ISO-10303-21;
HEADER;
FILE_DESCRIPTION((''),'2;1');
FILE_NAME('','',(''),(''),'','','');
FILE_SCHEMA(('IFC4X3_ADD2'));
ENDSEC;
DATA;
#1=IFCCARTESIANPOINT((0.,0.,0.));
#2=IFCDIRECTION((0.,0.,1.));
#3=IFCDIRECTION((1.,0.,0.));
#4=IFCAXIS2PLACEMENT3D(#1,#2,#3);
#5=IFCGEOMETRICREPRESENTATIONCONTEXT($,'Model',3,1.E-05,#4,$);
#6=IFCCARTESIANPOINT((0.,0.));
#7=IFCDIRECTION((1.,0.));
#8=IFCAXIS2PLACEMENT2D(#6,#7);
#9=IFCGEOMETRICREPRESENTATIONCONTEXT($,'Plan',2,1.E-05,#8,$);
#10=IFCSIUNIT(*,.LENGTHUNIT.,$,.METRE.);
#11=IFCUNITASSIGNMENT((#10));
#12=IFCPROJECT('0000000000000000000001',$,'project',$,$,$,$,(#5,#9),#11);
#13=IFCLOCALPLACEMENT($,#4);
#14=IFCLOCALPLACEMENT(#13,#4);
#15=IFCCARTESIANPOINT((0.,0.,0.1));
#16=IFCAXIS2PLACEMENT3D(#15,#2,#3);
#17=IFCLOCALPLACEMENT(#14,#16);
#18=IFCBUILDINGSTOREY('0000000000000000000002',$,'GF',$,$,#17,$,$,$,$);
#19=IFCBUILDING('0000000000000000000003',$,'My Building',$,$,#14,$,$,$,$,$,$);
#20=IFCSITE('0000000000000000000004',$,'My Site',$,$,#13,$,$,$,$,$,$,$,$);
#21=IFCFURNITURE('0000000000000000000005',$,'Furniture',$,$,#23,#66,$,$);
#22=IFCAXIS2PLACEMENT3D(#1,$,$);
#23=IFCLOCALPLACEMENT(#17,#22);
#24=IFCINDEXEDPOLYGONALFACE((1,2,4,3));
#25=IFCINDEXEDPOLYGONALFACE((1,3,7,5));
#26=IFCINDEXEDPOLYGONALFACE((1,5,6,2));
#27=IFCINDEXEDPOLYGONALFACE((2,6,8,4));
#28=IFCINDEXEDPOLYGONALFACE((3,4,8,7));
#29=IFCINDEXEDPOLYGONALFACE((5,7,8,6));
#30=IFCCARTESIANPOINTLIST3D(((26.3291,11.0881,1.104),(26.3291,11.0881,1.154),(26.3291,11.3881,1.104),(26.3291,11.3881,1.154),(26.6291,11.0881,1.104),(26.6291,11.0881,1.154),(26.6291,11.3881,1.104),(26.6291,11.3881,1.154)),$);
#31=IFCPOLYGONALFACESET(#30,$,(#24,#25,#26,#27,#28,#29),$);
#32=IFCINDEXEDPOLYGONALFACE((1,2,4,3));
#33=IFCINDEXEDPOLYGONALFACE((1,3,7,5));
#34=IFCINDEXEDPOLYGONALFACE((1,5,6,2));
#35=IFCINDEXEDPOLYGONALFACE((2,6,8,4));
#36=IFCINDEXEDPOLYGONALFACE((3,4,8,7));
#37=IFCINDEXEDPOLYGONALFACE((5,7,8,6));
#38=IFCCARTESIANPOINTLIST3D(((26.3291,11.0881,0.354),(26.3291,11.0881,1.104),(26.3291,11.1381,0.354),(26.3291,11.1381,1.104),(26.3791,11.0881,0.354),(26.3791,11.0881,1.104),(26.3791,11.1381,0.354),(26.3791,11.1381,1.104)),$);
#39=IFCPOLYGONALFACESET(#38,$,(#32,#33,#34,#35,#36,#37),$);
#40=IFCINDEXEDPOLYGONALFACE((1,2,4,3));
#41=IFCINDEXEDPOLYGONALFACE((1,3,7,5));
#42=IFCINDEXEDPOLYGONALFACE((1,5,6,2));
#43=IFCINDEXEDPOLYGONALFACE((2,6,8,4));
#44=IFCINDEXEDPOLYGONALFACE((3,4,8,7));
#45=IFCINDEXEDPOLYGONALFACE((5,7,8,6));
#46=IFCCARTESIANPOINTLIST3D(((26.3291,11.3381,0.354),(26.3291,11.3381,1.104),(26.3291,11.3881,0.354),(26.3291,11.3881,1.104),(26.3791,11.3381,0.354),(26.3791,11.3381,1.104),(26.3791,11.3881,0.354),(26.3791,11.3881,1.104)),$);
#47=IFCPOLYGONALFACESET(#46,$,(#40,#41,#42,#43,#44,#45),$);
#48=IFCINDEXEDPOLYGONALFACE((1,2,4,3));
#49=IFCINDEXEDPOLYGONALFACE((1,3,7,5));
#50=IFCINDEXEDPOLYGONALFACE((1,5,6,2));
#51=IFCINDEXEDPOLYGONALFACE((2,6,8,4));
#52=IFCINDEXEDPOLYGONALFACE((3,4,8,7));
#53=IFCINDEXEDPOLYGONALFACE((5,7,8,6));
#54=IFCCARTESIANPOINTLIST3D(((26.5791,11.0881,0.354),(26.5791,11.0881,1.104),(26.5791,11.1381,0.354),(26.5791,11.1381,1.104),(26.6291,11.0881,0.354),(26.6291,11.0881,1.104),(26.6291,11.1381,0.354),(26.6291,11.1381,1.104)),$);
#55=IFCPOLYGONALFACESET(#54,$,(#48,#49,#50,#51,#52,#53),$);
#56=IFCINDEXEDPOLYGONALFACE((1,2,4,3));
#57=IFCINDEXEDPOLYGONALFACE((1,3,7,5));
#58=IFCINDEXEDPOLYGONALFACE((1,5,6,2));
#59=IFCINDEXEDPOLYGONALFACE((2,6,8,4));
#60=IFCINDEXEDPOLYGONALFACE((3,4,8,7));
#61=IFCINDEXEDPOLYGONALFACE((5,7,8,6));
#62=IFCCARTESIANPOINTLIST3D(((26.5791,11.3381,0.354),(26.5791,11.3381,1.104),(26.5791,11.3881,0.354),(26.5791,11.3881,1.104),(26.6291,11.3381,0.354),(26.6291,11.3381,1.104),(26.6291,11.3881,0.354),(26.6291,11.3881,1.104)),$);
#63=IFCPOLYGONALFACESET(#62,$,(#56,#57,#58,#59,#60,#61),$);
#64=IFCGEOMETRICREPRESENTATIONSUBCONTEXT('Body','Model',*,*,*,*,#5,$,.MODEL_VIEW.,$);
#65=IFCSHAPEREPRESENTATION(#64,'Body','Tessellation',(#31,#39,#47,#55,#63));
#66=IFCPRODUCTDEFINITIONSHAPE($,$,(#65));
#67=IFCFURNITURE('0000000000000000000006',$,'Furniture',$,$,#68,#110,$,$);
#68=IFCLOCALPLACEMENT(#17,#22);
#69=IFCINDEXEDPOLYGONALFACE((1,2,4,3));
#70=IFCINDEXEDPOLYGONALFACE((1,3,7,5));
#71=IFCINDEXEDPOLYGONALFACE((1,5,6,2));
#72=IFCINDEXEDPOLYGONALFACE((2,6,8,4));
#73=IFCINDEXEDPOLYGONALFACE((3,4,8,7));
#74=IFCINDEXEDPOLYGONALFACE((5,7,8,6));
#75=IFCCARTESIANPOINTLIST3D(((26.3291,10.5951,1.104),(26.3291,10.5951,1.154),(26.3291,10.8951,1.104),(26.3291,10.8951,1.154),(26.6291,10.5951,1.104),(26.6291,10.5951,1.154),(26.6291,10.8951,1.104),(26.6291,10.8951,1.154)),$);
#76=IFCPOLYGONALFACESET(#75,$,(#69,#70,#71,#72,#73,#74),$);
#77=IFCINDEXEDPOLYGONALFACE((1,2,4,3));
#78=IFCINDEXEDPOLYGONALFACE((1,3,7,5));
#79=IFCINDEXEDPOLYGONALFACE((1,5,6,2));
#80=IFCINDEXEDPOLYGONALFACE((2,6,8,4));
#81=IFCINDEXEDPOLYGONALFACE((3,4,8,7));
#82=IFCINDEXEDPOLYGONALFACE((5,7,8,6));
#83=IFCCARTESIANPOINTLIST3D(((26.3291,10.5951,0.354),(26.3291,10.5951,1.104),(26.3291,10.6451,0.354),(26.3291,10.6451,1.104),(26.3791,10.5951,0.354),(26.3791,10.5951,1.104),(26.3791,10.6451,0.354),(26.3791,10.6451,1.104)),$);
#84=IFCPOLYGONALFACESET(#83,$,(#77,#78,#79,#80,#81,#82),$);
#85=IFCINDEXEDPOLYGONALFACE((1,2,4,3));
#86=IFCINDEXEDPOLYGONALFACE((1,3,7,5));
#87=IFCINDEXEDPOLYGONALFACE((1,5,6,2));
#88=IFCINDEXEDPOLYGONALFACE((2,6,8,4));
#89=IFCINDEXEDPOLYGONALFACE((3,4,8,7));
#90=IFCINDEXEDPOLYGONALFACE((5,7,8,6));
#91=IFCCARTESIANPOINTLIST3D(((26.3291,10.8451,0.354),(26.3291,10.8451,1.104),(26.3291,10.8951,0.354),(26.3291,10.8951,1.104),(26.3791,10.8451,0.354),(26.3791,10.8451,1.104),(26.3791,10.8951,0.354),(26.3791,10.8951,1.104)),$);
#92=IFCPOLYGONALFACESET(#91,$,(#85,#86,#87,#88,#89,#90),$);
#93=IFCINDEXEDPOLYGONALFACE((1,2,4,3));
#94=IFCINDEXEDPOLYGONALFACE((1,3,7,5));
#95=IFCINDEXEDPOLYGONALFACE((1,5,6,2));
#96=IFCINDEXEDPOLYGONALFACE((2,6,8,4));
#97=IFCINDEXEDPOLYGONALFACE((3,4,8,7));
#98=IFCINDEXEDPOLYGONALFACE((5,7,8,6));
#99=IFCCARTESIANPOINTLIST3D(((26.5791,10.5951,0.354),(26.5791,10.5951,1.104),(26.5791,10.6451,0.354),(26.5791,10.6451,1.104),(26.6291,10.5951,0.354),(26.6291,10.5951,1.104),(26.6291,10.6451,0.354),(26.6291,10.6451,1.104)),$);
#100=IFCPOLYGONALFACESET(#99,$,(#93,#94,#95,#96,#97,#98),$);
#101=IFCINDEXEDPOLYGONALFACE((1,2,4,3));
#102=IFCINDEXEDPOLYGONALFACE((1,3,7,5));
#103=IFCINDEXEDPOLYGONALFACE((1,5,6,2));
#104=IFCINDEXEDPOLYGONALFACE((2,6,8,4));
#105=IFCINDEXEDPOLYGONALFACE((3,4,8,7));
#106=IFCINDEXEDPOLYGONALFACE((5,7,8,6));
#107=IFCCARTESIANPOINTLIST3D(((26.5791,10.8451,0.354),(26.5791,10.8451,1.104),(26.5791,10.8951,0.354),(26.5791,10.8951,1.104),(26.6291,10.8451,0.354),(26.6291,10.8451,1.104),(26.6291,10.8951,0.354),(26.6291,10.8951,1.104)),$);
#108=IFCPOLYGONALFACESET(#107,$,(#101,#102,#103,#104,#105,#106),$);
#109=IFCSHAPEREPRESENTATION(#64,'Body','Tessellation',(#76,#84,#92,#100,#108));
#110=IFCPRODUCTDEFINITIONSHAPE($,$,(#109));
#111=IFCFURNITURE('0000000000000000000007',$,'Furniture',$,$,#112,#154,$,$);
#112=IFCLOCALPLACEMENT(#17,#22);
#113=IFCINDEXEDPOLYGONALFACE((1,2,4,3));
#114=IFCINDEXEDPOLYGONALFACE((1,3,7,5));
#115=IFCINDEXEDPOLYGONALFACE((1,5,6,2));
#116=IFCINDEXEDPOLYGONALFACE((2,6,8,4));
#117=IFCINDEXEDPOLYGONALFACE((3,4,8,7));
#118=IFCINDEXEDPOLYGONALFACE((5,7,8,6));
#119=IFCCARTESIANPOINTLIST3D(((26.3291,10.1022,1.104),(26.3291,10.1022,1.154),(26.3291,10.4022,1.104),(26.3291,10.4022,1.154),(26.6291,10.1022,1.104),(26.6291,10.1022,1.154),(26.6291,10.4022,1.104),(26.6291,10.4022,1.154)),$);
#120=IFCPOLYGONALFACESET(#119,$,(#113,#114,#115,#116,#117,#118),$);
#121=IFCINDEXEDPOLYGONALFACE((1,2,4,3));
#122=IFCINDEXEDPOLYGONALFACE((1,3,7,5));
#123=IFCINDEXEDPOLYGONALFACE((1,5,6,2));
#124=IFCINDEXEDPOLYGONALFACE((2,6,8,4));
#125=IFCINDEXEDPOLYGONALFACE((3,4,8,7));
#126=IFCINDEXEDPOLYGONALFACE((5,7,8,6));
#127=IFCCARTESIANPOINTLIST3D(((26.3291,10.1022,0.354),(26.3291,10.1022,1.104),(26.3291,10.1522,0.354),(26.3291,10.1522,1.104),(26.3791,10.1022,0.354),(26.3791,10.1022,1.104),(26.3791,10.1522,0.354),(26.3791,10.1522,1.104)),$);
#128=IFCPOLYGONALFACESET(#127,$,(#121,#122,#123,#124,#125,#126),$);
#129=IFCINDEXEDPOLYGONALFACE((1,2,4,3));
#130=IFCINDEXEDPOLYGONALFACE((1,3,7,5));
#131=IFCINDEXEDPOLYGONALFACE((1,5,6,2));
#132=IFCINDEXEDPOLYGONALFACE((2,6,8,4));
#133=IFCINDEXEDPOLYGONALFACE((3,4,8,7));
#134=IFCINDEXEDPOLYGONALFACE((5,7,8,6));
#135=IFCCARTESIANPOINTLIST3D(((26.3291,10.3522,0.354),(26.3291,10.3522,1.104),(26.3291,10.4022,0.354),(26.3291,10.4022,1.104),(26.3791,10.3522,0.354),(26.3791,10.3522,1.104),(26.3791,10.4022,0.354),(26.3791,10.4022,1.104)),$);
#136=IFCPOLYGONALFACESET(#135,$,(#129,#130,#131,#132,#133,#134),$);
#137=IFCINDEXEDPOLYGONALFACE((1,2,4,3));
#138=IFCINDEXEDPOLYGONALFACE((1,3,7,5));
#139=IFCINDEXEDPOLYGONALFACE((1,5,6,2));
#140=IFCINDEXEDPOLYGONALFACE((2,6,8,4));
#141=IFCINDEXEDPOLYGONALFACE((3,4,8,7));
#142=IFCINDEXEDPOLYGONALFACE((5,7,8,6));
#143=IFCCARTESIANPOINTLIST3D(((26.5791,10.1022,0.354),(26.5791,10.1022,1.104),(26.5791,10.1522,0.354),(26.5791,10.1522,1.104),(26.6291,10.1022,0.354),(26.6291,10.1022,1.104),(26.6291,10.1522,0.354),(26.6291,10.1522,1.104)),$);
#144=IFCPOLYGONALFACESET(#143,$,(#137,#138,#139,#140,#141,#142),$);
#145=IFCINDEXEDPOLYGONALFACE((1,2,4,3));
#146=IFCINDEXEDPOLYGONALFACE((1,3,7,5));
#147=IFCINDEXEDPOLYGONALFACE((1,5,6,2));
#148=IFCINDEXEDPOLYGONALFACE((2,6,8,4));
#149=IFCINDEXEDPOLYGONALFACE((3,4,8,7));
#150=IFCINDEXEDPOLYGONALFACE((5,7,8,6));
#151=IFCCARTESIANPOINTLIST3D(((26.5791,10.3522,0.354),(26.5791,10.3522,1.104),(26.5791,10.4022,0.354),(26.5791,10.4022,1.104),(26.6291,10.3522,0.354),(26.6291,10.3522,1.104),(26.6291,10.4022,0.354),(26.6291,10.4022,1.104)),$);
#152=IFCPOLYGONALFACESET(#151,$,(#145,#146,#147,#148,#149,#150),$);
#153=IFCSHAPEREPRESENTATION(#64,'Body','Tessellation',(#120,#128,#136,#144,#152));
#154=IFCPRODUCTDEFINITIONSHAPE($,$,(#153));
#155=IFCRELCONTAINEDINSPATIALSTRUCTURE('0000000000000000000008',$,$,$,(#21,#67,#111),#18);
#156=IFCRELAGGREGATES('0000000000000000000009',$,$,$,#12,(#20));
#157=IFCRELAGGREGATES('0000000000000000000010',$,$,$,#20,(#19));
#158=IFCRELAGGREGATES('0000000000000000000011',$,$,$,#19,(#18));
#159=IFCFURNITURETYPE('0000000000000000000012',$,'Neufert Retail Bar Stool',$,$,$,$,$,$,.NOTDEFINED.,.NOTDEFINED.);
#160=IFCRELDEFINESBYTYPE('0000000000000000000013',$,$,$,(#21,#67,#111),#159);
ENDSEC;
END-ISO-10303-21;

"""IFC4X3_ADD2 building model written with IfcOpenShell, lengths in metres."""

from ifc_helpers import new_model, entity, si_unit, frame, origin_with_axes, origin_2d_with_axis, place, context, subcontext, project, spatial, line, indexed_curve, outline, extrude, shape, source, transform, mapped, type_object, type_shapes, element, save


model = new_model("IFC4X3_ADD2")

# Units and contexts
model_context = context("Model", 3, precision=1e-05, world=origin_with_axes())
plan_context = context("Plan", 2, precision=1e-05, world=origin_2d_with_axis())
body_context_1 = subcontext(model_context, "Body", "Model", "MODEL_VIEW")
body_context_2 = subcontext(plan_context, "Body", "Plan", "PLAN_VIEW")
ifc_project = project(units=[si_unit("LENGTHUNIT", "METRE")], contexts=[model_context, plan_context])

# Site, building, storey
site_placement = place(None, origin_with_axes())
site = spatial("IfcSite", under=ifc_project, at=site_placement, Name="My Site")
building_placement = place(site_placement, origin_with_axes())
building = spatial("IfcBuilding", under=site, at=building_placement, Name="My Building")
storey_placement = place(building_placement, frame((0.0, 0.0, 0.1), z_axis=(0.0, 0.0, 1.0), x_axis=(1.0, 0.0, 0.0)))
storey = spatial("IfcBuildingStorey", under=building, at=storey_placement, Name="GF")

# Furniture
furniture_type = type_object("IfcFurnitureType", Name="Neufert Retail Bar Stool", AssemblyPlace="NOTDEFINED", PredefinedType="NOTDEFINED")
shared_shape_1 = source(origin_with_axes(), body_context_1, "Body", "SweptSolid", [
    extrude(outline(indexed_curve([(0.15, 0.0), (-0.15, 0.0), (-0.15, -0.3), (0.15, -0.3)], segments=[line(3, 2), line(2, 1), line(1, 4), line(4, 3)], self_intersect=False)), frame((0.0, 0.0, 0.8), z_axis=(0.0, 0.0, 1.0), x_axis=(1.0, 0.0, 0.0)), (0.0, 0.0, -1.0), 0.05),
    extrude(outline(indexed_curve([(-0.15, 0.0), (-0.1, 0.0), (-0.1, -0.05), (-0.15, -0.05)], segments=[line(1, 2, 3, 4, 1)])), origin_with_axes(), (0.0, 0.0, 1.0), 0.75),
    extrude(outline(indexed_curve([(0.15, 0.0), (0.1, 0.0), (0.1, -0.05), (0.15, -0.05)], segments=[line(1, 2, 3, 4, 1)])), origin_with_axes(), (0.0, 0.0, 1.0), 0.75),
    extrude(outline(indexed_curve([(-0.15, -0.3), (-0.1, -0.3), (-0.1, -0.25), (-0.15, -0.25)], segments=[line(1, 2, 3, 4, 1)])), origin_with_axes(), (0.0, 0.0, 1.0), 0.75),
    extrude(outline(indexed_curve([(0.15, -0.3), (0.1, -0.3), (0.1, -0.25), (0.15, -0.25)], segments=[line(1, 2, 3, 4, 1)])), origin_with_axes(), (0.0, 0.0, 1.0), 0.75),
])
shared_shape_2 = source(origin_with_axes(), body_context_2, "Body", "Curve2D", [
    entity("IfcIndexedPolyCurve", entity("IfcCartesianPointList2D", [[-0.15, -0.3], [0.15, -0.3]])),
    entity("IfcIndexedPolyCurve", entity("IfcCartesianPointList2D", [[-0.15, -0.3], [-0.15, -0.15], [-0.1061, -0.0439], [0.0, 0.0], [0.1061, -0.0439], [0.15, -0.15], [0.15, -0.3]]), [entity("IfcLineIndex", [1, 2]), entity("IfcArcIndex", [2, 3, 4]), entity("IfcArcIndex", [4, 5, 6]), entity("IfcLineIndex", [6, 7])]),
    entity("IfcIndexedPolyCurve", entity("IfcCartesianPointList2D", [[-0.12, -0.3], [-0.12, -0.15], [-0.0849, -0.0651], [0.0, -0.03], [0.0849, -0.0651], [0.12, -0.15], [0.12, -0.3]]), [entity("IfcLineIndex", [1, 2]), entity("IfcArcIndex", [2, 3, 4]), entity("IfcArcIndex", [4, 5, 6]), entity("IfcLineIndex", [6, 7])]),
])
type_shapes(furniture_type, [shared_shape_1, shared_shape_2])
for number, where, z_axis, x_axis, name in (
    (1, (26.3291, 11.2381, 0.354), (0.0, 0.0, 1.0), (0.0, 1.0, 0.0), "Furniture"),
    (2, (26.3291, 10.7451, 0.354), (0.0, 0.0, 1.0), (0.0, 1.0, 0.0), "Furniture"),
    (3, (26.3291, 10.2522, 0.354), (0.0, 0.0, 1.0), (0.0, 1.0, 0.0), "Furniture"),
):
    element("IfcFurniture", number, at=place(storey_placement, frame(where, z_axis=z_axis, x_axis=x_axis)), inside=storey, type_object=furniture_type, Name=name, shapes=[
        shape(body_context_1, "Body", "MappedRepresentation", [mapped(shared_shape_1, transform((0.0, 0.0, 0.0), x_axis=(1.0, 0.0, 0.0), y_axis=(0.0, 1.0, 0.0), z_axis=(0.0, 0.0, 1.0), scale=1.0))]),
        shape(body_context_2, "Body", "MappedRepresentation", [mapped(shared_shape_2, transform((0.0, 0.0, 0.0), x_axis=(1.0, 0.0, 0.0), y_axis=(0.0, 1.0, 0.0), z_axis=(0.0, 0.0, 1.0), scale=1.0))]),
    ])

save(model, "model.ifc")
